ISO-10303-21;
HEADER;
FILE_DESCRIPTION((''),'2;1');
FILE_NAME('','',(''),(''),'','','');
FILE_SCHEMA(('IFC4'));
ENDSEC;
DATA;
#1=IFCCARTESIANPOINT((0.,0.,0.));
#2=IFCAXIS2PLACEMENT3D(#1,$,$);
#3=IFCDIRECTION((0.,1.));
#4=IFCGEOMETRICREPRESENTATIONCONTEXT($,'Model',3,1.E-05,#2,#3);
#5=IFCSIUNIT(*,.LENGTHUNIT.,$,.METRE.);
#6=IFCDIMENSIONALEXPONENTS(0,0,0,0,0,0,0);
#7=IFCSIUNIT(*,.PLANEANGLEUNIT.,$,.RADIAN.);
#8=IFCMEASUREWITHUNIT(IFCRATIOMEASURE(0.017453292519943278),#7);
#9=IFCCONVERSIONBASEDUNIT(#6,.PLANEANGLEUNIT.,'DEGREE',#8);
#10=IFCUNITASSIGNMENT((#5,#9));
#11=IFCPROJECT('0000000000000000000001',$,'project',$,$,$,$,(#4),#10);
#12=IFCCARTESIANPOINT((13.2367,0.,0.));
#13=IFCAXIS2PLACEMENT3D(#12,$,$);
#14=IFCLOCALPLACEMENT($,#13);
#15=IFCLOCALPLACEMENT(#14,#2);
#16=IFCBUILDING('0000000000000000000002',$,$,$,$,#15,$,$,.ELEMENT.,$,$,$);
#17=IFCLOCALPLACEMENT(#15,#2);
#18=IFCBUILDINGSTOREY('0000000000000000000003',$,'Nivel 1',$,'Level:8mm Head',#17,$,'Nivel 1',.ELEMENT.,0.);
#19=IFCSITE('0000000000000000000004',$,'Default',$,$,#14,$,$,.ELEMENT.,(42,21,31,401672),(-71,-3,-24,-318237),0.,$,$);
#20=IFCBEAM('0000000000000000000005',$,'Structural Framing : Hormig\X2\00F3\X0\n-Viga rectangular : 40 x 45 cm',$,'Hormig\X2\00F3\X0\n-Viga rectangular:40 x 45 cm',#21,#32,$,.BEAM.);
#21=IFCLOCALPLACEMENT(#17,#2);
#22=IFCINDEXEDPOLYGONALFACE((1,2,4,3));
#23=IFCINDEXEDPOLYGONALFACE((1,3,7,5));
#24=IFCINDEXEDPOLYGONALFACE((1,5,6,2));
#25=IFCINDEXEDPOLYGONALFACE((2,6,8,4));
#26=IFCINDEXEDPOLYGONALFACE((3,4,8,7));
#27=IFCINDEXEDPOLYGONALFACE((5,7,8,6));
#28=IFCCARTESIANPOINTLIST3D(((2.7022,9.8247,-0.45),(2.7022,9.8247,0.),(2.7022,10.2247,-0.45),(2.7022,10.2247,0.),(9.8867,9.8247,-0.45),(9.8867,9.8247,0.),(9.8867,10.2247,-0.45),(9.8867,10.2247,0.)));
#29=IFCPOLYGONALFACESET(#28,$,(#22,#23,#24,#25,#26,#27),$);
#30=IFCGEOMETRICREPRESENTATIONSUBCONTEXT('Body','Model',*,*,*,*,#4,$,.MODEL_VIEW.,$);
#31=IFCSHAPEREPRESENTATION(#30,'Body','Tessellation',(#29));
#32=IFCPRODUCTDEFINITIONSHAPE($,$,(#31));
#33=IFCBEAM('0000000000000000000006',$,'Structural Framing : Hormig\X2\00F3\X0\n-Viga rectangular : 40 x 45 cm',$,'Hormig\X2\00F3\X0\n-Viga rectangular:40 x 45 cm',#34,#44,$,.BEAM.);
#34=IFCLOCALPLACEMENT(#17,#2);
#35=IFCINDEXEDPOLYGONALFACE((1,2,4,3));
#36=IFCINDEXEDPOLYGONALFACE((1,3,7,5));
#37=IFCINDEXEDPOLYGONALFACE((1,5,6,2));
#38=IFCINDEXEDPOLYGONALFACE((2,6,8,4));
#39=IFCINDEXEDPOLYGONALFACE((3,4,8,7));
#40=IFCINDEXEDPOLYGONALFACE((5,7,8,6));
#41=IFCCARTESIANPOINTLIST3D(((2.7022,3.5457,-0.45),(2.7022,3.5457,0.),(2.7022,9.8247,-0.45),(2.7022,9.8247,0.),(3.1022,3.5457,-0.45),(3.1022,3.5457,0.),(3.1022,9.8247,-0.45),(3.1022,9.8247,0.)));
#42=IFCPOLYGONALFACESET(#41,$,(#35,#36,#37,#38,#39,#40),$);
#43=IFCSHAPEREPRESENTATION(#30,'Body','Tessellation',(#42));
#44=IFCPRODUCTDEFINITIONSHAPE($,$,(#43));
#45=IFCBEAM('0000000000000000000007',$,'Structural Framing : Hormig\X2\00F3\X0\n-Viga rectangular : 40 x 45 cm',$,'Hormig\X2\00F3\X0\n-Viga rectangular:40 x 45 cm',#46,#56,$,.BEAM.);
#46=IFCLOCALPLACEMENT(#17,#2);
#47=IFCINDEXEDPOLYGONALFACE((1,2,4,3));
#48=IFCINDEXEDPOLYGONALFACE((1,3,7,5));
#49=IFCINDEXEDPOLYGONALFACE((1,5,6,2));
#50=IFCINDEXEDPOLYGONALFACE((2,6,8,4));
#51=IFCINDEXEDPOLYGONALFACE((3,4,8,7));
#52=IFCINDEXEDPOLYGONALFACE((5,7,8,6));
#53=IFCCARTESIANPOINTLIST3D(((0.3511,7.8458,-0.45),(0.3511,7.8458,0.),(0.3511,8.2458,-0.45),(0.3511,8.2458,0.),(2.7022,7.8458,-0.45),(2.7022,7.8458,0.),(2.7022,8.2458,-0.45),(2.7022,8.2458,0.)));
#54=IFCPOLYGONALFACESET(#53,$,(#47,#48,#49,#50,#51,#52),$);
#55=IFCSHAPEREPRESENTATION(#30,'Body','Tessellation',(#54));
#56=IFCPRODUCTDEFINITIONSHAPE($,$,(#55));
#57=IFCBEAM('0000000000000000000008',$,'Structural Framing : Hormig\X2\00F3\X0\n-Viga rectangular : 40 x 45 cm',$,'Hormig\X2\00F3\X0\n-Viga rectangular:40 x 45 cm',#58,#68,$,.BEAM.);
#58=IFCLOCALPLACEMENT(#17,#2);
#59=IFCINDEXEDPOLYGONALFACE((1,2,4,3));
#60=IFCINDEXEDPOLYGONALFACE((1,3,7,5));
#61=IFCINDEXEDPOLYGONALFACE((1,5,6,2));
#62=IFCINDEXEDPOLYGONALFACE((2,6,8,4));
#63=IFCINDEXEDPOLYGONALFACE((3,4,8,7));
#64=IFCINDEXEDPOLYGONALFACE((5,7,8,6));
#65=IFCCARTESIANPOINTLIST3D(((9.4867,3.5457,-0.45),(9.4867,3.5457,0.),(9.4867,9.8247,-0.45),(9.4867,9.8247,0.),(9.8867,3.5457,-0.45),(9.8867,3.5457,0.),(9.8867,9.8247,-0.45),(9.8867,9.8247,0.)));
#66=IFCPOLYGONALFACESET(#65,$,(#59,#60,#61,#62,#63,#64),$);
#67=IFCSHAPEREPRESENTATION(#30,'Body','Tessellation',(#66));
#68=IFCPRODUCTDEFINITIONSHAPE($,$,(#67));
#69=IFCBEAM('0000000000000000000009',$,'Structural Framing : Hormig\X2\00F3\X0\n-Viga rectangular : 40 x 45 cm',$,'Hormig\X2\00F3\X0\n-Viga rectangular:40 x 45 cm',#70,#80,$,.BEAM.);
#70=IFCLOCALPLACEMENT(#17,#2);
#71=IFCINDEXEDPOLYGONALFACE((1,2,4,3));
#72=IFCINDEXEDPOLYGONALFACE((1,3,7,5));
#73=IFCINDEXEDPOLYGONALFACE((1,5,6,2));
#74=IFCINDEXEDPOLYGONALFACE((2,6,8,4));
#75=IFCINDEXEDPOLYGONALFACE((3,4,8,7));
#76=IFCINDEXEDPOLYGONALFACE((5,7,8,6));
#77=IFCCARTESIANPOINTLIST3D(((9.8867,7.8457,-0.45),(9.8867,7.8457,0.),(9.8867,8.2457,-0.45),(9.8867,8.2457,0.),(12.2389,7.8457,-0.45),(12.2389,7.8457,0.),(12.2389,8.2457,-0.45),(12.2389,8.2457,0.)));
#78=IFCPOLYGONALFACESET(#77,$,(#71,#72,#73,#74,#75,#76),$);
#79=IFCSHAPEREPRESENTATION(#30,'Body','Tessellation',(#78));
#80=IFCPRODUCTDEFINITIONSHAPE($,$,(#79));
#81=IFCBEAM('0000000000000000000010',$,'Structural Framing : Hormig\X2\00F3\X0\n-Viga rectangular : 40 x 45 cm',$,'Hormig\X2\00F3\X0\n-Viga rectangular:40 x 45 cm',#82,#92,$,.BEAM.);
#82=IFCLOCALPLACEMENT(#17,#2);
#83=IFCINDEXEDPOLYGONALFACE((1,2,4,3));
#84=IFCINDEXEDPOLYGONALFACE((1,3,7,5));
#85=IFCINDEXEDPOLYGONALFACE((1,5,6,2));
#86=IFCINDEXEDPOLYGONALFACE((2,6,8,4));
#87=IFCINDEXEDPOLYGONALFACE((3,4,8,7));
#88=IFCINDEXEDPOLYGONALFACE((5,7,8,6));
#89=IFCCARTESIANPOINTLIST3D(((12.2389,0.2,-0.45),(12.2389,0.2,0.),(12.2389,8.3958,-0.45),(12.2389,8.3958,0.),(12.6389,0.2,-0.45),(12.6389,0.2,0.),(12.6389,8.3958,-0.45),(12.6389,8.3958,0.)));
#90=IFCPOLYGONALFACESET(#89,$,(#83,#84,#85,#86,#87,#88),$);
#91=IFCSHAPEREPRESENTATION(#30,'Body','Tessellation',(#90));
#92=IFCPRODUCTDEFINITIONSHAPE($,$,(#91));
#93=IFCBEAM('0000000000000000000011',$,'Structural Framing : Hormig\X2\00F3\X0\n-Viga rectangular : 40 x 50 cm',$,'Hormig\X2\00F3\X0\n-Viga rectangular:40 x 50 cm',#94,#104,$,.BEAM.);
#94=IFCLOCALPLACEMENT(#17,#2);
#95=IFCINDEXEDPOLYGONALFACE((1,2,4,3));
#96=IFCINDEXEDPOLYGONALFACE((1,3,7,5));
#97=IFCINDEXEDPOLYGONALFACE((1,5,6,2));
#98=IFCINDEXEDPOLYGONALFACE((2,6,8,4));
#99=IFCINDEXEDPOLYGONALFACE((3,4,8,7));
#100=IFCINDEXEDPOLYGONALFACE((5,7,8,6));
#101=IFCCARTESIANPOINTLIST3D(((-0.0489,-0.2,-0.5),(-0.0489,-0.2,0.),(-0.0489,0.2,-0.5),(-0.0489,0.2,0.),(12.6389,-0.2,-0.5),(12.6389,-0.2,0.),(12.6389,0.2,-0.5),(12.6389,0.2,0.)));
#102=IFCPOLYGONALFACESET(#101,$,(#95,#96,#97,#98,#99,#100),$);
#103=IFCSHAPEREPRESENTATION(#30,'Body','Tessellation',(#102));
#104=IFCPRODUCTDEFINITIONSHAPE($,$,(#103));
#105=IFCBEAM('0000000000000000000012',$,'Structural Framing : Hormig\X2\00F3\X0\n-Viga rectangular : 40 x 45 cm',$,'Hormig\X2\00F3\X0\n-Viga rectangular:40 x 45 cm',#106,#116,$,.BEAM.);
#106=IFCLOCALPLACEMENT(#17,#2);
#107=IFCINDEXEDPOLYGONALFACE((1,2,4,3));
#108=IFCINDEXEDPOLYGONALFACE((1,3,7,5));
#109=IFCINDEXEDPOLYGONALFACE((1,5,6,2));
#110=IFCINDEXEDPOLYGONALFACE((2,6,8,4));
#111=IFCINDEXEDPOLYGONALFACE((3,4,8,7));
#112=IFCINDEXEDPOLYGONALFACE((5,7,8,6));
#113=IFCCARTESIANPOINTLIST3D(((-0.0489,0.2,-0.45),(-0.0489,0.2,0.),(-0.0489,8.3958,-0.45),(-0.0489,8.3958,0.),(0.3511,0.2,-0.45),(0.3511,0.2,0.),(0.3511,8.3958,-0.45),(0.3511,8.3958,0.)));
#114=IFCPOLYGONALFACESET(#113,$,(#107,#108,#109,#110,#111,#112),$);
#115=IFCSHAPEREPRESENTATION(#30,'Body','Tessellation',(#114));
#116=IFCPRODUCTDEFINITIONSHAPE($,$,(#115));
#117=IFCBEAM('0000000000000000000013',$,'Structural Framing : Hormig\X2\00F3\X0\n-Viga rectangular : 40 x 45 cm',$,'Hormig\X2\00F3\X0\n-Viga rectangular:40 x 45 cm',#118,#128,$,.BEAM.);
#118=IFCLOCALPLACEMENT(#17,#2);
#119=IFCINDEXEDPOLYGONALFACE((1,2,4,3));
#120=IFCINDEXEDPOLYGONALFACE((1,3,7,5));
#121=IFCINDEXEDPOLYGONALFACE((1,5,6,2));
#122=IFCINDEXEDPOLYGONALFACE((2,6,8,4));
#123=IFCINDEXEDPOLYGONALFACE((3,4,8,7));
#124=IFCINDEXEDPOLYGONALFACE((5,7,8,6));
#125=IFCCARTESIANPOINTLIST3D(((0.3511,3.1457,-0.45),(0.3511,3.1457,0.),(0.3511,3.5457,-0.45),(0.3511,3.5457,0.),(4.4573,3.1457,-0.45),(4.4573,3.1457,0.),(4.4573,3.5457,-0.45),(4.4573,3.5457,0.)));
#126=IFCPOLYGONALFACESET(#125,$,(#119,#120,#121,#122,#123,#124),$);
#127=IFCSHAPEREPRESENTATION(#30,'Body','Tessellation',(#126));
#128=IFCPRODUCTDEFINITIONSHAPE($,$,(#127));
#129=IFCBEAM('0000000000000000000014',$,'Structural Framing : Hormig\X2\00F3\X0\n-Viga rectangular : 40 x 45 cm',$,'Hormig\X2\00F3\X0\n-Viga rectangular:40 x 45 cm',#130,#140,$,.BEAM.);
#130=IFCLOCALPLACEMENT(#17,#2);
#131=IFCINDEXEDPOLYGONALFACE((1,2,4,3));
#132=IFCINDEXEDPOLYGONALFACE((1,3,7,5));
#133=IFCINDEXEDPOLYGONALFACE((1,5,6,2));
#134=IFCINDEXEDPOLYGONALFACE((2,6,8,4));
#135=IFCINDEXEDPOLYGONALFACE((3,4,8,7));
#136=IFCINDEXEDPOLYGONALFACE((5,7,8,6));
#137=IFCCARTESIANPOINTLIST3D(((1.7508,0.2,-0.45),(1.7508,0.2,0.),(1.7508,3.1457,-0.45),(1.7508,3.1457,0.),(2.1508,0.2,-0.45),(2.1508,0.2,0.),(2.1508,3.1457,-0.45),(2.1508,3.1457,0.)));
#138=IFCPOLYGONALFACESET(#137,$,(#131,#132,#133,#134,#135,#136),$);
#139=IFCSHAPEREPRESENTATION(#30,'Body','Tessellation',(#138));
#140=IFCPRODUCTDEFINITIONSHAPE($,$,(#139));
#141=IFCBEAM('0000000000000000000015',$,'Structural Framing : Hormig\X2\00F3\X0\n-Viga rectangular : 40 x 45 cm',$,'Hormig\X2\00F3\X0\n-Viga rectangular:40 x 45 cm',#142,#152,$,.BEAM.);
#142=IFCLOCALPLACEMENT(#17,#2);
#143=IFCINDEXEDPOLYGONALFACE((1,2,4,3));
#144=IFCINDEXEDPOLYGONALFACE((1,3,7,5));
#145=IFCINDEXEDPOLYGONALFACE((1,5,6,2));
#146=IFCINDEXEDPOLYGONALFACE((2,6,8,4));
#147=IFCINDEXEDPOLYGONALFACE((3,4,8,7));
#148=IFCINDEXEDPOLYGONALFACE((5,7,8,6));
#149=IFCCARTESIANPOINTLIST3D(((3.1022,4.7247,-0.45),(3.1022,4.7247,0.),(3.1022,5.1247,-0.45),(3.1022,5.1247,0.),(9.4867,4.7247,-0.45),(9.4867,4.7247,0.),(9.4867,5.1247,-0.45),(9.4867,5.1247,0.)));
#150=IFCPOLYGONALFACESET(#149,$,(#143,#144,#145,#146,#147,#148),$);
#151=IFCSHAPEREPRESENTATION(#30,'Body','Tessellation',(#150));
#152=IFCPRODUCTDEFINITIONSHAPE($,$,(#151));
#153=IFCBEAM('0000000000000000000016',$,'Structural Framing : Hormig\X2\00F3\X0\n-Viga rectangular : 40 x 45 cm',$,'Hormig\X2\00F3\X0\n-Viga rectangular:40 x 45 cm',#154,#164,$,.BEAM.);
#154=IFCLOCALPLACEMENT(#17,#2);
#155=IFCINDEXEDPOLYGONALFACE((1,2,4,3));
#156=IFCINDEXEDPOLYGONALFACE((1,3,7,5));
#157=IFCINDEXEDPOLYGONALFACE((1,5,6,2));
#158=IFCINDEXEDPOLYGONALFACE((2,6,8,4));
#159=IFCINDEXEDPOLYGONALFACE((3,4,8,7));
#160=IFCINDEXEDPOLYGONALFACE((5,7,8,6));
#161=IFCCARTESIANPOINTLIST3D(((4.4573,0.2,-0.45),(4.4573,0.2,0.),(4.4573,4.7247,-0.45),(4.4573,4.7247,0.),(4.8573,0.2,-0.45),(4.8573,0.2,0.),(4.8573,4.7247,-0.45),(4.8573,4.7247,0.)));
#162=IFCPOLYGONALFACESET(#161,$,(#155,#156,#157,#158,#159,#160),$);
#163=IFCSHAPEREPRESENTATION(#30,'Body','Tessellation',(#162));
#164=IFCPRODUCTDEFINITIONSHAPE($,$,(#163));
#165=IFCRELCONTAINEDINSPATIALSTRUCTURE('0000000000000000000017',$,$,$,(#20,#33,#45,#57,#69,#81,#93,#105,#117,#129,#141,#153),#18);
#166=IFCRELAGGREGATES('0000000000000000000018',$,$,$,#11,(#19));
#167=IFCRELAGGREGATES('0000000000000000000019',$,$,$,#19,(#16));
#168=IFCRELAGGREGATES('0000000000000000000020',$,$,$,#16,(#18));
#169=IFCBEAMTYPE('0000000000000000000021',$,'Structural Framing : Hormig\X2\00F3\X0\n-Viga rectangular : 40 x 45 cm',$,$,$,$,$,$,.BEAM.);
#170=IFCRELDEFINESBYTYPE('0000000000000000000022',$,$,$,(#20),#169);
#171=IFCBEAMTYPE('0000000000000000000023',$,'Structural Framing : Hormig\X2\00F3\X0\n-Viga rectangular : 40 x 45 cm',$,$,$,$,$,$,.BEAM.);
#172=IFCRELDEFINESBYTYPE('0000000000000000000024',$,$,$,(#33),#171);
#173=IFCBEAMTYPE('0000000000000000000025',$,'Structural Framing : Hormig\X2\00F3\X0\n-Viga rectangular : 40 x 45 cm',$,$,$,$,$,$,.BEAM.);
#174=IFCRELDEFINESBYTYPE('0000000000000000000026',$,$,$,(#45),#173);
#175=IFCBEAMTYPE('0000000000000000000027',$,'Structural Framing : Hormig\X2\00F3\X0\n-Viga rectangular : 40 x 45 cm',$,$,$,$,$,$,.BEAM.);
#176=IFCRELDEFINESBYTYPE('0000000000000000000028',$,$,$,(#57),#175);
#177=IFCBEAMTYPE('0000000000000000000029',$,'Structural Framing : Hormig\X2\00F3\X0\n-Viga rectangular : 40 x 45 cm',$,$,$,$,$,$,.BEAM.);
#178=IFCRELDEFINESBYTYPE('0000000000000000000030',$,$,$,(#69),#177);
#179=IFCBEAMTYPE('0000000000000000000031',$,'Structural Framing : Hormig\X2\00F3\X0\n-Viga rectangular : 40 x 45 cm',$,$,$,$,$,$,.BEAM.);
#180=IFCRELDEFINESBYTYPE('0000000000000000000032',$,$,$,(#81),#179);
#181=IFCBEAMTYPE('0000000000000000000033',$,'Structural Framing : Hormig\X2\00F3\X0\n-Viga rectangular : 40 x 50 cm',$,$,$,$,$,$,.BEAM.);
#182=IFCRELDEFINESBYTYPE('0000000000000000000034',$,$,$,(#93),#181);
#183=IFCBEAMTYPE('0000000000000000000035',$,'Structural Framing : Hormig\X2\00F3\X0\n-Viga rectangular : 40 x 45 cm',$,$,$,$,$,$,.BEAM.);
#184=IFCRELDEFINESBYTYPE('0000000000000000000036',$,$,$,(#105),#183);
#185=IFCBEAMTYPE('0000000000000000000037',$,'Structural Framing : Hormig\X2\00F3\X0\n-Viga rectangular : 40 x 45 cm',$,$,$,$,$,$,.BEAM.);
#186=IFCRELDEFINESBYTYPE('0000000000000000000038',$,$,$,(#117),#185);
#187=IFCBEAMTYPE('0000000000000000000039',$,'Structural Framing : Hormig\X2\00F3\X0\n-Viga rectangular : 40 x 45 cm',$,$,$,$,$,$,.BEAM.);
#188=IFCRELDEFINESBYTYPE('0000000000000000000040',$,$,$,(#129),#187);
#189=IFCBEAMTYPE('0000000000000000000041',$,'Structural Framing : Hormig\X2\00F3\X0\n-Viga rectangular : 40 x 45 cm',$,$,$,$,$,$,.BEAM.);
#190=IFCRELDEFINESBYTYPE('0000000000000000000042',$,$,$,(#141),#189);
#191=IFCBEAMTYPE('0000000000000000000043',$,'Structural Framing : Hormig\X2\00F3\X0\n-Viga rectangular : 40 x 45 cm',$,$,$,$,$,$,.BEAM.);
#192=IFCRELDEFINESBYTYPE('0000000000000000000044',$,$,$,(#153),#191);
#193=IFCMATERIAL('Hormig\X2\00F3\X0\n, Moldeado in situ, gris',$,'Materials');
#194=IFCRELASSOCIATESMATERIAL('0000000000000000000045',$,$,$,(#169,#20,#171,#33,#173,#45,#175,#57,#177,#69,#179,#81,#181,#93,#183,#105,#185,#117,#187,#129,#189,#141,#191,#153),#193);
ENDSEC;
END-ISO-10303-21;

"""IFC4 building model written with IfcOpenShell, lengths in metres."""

from ifc_helpers import new_model, entity, si_unit, converted_unit, direction, frame, origin, place, context, subcontext, project, spatial, indexed_curve, outline, extrude, source, transform, mapped, material, type_object, type_shapes, element, save


model = new_model("IFC4")

# Units and contexts
model_context = context("Model", 3, precision=1e-05, world=origin(), true_north=direction((0.0, 1.0)))
body_context = subcontext(model_context, "Body", "Model", "MODEL_VIEW")
ifc_project = project(units=[si_unit("LENGTHUNIT", "METRE"), converted_unit("PLANEANGLEUNIT", "DEGREE", entity("IfcRatioMeasure", 0.017453292519943278), si_unit("PLANEANGLEUNIT", "RADIAN"), dimensions=[0, 0, 0, 0, 0, 0, 0])], contexts=[model_context])

# Site, building, storey
site_placement = place(None, frame((13.2367, 0.0, 0.0)))
site = spatial("IfcSite", under=ifc_project, at=site_placement, Name="Default", CompositionType="ELEMENT", RefLatitude=(42, 21, 31, 401672), RefLongitude=(-71, -3, -24, -318237), RefElevation=0.0)
building_placement = place(site_placement, origin())
building = spatial("IfcBuilding", under=site, at=building_placement, CompositionType="ELEMENT")
storey_placement = place(building_placement, origin())
storey = spatial("IfcBuildingStorey", under=building, at=storey_placement, Name="Nivel 1", ObjectType="Level:8mm Head", LongName="Nivel 1", CompositionType="ELEMENT", Elevation=0.0)

# Beams
ifc_material_1 = material(Name="Hormigón, Moldeado in situ, gris", Category="Materials")
beam_type_1 = type_object("IfcBeamType", Name="Structural Framing : Hormigón-Viga rectangular : 40 x 45 cm", PredefinedType="BEAM", material=ifc_material_1)
shared_shape_1 = source(origin(), body_context, "Body", "SweptSolid", [
    extrude(outline(indexed_curve([(-0.225, -0.2), (0.225, -0.2), (0.225, 0.2), (-0.225, 0.2), (-0.225, -0.2)], self_intersect=False)), frame((2.7022, 10.0247, -0.225), z_axis=(1.0, 0.0, 0.0), x_axis=(0.0, 0.0, -1.0)), (0.0, 0.0, 1.0), 7.1845),
])
type_shapes(beam_type_1, [shared_shape_1])
beam_1_placement = place(storey_placement, origin())
element("IfcBeam", 1, at=beam_1_placement, inside=storey, type_object=beam_type_1, material=ifc_material_1, Name="Structural Framing : Hormigón-Viga rectangular : 40 x 45 cm", ObjectType="Hormigón-Viga rectangular:40 x 45 cm", PredefinedType="BEAM", context=body_context, shape_type="MappedRepresentation", body=[
    mapped(shared_shape_1, transform((0.0, 0.0, 0.0), scale=1.0)),
])
beam_type_2 = type_object("IfcBeamType", Name="Structural Framing : Hormigón-Viga rectangular : 40 x 45 cm", PredefinedType="BEAM", material=ifc_material_1)
shared_shape_2 = source(origin(), body_context, "Body", "SweptSolid", [
    extrude(outline(indexed_curve([(-0.2, -0.225), (0.2, -0.225), (0.2, 0.225), (-0.2, 0.225), (-0.2, -0.225)], self_intersect=False)), frame((2.9022, 3.5457, -0.225), z_axis=(0.0, 1.0, 0.0), x_axis=(-1.0, 0.0, 0.0)), (0.0, 0.0, 1.0), 6.279),
])
type_shapes(beam_type_2, [shared_shape_2])
beam_2_placement = place(storey_placement, origin())
element("IfcBeam", 2, at=beam_2_placement, inside=storey, type_object=beam_type_2, material=ifc_material_1, Name="Structural Framing : Hormigón-Viga rectangular : 40 x 45 cm", ObjectType="Hormigón-Viga rectangular:40 x 45 cm", PredefinedType="BEAM", context=body_context, shape_type="MappedRepresentation", body=[
    mapped(shared_shape_2, transform((0.0, 0.0, 0.0), scale=1.0)),
])
beam_type_3 = type_object("IfcBeamType", Name="Structural Framing : Hormigón-Viga rectangular : 40 x 45 cm", PredefinedType="BEAM", material=ifc_material_1)
shared_shape_3 = source(origin(), body_context, "Body", "SweptSolid", [
    extrude(outline(indexed_curve([(-0.225, -0.2), (0.225, -0.2), (0.225, 0.2), (-0.225, 0.2), (-0.225, -0.2)], self_intersect=False)), frame((0.3511, 8.0458, -0.225), z_axis=(1.0, 0.0, 0.0), x_axis=(0.0, 0.0, -1.0)), (0.0, 0.0, 1.0), 2.351),
])
type_shapes(beam_type_3, [shared_shape_3])
beam_3_placement = place(storey_placement, origin())
element("IfcBeam", 3, at=beam_3_placement, inside=storey, type_object=beam_type_3, material=ifc_material_1, Name="Structural Framing : Hormigón-Viga rectangular : 40 x 45 cm", ObjectType="Hormigón-Viga rectangular:40 x 45 cm", PredefinedType="BEAM", context=body_context, shape_type="MappedRepresentation", body=[
    mapped(shared_shape_3, transform((0.0, 0.0, 0.0), scale=1.0)),
])
beam_type_4 = type_object("IfcBeamType", Name="Structural Framing : Hormigón-Viga rectangular : 40 x 45 cm", PredefinedType="BEAM", material=ifc_material_1)
shared_shape_4 = source(origin(), body_context, "Body", "SweptSolid", [
    extrude(outline(indexed_curve([(-0.2, -0.225), (0.2, -0.225), (0.2, 0.225), (-0.2, 0.225), (-0.2, -0.225)], self_intersect=False)), frame((9.6867, 9.8247, -0.225), z_axis=(0.0, -1.0, 0.0), x_axis=(-1.0, 0.0, 0.0)), (0.0, 0.0, 1.0), 6.279),
])
type_shapes(beam_type_4, [shared_shape_4])
beam_4_placement = place(storey_placement, origin())
element("IfcBeam", 4, at=beam_4_placement, inside=storey, type_object=beam_type_4, material=ifc_material_1, Name="Structural Framing : Hormigón-Viga rectangular : 40 x 45 cm", ObjectType="Hormigón-Viga rectangular:40 x 45 cm", PredefinedType="BEAM", context=body_context, shape_type="MappedRepresentation", body=[
    mapped(shared_shape_4, transform((0.0, 0.0, 0.0), scale=1.0)),
])
beam_type_5 = type_object("IfcBeamType", Name="Structural Framing : Hormigón-Viga rectangular : 40 x 45 cm", PredefinedType="BEAM", material=ifc_material_1)
shared_shape_5 = source(origin(), body_context, "Body", "SweptSolid", [
    extrude(outline(indexed_curve([(-0.225, -0.2), (0.225, -0.2), (0.225, 0.2), (-0.225, 0.2), (-0.225, -0.2)], self_intersect=False)), frame((9.8867, 8.0457, -0.225), z_axis=(1.0, 0.0, 0.0), x_axis=(0.0, 0.0, -1.0)), (0.0, 0.0, 1.0), 2.3522),
])
type_shapes(beam_type_5, [shared_shape_5])
beam_5_placement = place(storey_placement, origin())
element("IfcBeam", 5, at=beam_5_placement, inside=storey, type_object=beam_type_5, material=ifc_material_1, Name="Structural Framing : Hormigón-Viga rectangular : 40 x 45 cm", ObjectType="Hormigón-Viga rectangular:40 x 45 cm", PredefinedType="BEAM", context=body_context, shape_type="MappedRepresentation", body=[
    mapped(shared_shape_5, transform((0.0, 0.0, 0.0), scale=1.0)),
])
beam_type_6 = type_object("IfcBeamType", Name="Structural Framing : Hormigón-Viga rectangular : 40 x 45 cm", PredefinedType="BEAM", material=ifc_material_1)
shared_shape_6 = source(origin(), body_context, "Body", "SweptSolid", [
    extrude(outline(indexed_curve([(-0.2, -0.225), (0.2, -0.225), (0.2, 0.225), (-0.2, 0.225), (-0.2, -0.225)], self_intersect=False)), frame((12.4389, 8.3958, -0.225), z_axis=(0.0, -1.0, 0.0), x_axis=(-1.0, 0.0, 0.0)), (0.0, 0.0, 1.0), 8.1958),
])
type_shapes(beam_type_6, [shared_shape_6])
beam_6_placement = place(storey_placement, origin())
element("IfcBeam", 6, at=beam_6_placement, inside=storey, type_object=beam_type_6, material=ifc_material_1, Name="Structural Framing : Hormigón-Viga rectangular : 40 x 45 cm", ObjectType="Hormigón-Viga rectangular:40 x 45 cm", PredefinedType="BEAM", context=body_context, shape_type="MappedRepresentation", body=[
    mapped(shared_shape_6, transform((0.0, 0.0, 0.0), scale=1.0)),
])
beam_type_7 = type_object("IfcBeamType", Name="Structural Framing : Hormigón-Viga rectangular : 40 x 50 cm", PredefinedType="BEAM", material=ifc_material_1)
shared_shape_7 = source(origin(), body_context, "Body", "SweptSolid", [
    extrude(outline(indexed_curve([(-0.25, -0.2), (0.25, -0.2), (0.25, 0.2), (-0.25, 0.2), (-0.25, -0.2)], self_intersect=False)), frame((12.6389, 0.0, -0.25), z_axis=(-1.0, 0.0, 0.0), x_axis=(0.0, 0.0, -1.0)), (0.0, 0.0, 1.0), 12.6878),
])
type_shapes(beam_type_7, [shared_shape_7])
beam_7_placement = place(storey_placement, origin())
element("IfcBeam", 7, at=beam_7_placement, inside=storey, type_object=beam_type_7, material=ifc_material_1, Name="Structural Framing : Hormigón-Viga rectangular : 40 x 50 cm", ObjectType="Hormigón-Viga rectangular:40 x 50 cm", PredefinedType="BEAM", context=body_context, shape_type="MappedRepresentation", body=[
    mapped(shared_shape_7, transform((0.0, 0.0, 0.0), scale=1.0)),
])
beam_type_8 = type_object("IfcBeamType", Name="Structural Framing : Hormigón-Viga rectangular : 40 x 45 cm", PredefinedType="BEAM", material=ifc_material_1)
shared_shape_8 = source(origin(), body_context, "Body", "SweptSolid", [
    extrude(outline(indexed_curve([(-0.2, -0.225), (0.2, -0.225), (0.2, 0.225), (-0.2, 0.225), (-0.2, -0.225)], self_intersect=False)), frame((0.1511, 0.2, -0.225), z_axis=(0.0, 1.0, 0.0), x_axis=(-1.0, 0.0, 0.0)), (0.0, 0.0, 1.0), 8.1958),
])
type_shapes(beam_type_8, [shared_shape_8])
beam_8_placement = place(storey_placement, origin())
element("IfcBeam", 8, at=beam_8_placement, inside=storey, type_object=beam_type_8, material=ifc_material_1, Name="Structural Framing : Hormigón-Viga rectangular : 40 x 45 cm", ObjectType="Hormigón-Viga rectangular:40 x 45 cm", PredefinedType="BEAM", context=body_context, shape_type="MappedRepresentation", body=[
    mapped(shared_shape_8, transform((0.0, 0.0, 0.0), scale=1.0)),
])
beam_type_9 = type_object("IfcBeamType", Name="Structural Framing : Hormigón-Viga rectangular : 40 x 45 cm", PredefinedType="BEAM", material=ifc_material_1)
shared_shape_9 = source(origin(), body_context, "Body", "SweptSolid", [
    extrude(outline(indexed_curve([(-0.225, -0.2), (0.225, -0.2), (0.225, 0.2), (-0.225, 0.2), (-0.225, -0.2)], self_intersect=False)), frame((0.3511, 3.3457, -0.225), z_axis=(1.0, 0.0, 0.0), x_axis=(0.0, 0.0, -1.0)), (0.0, 0.0, 1.0), 4.1062),
])
type_shapes(beam_type_9, [shared_shape_9])
beam_9_placement = place(storey_placement, origin())
element("IfcBeam", 9, at=beam_9_placement, inside=storey, type_object=beam_type_9, material=ifc_material_1, Name="Structural Framing : Hormigón-Viga rectangular : 40 x 45 cm", ObjectType="Hormigón-Viga rectangular:40 x 45 cm", PredefinedType="BEAM", context=body_context, shape_type="MappedRepresentation", body=[
    mapped(shared_shape_9, transform((0.0, 0.0, 0.0), scale=1.0)),
])
beam_type_10 = type_object("IfcBeamType", Name="Structural Framing : Hormigón-Viga rectangular : 40 x 45 cm", PredefinedType="BEAM", material=ifc_material_1)
shared_shape_10 = source(origin(), body_context, "Body", "SweptSolid", [
    extrude(outline(indexed_curve([(-0.2, -0.225), (0.2, -0.225), (0.2, 0.225), (-0.2, 0.225), (-0.2, -0.225)], self_intersect=False)), frame((1.9508, 3.1457, -0.225), z_axis=(0.0, -1.0, 0.0), x_axis=(-1.0, 0.0, 0.0)), (0.0, 0.0, 1.0), 2.9457),
])
type_shapes(beam_type_10, [shared_shape_10])
beam_10_placement = place(storey_placement, origin())
element("IfcBeam", 10, at=beam_10_placement, inside=storey, type_object=beam_type_10, material=ifc_material_1, Name="Structural Framing : Hormigón-Viga rectangular : 40 x 45 cm", ObjectType="Hormigón-Viga rectangular:40 x 45 cm", PredefinedType="BEAM", context=body_context, shape_type="MappedRepresentation", body=[
    mapped(shared_shape_10, transform((0.0, 0.0, 0.0), scale=1.0)),
])
beam_type_11 = type_object("IfcBeamType", Name="Structural Framing : Hormigón-Viga rectangular : 40 x 45 cm", PredefinedType="BEAM", material=ifc_material_1)
shared_shape_11 = source(origin(), body_context, "Body", "SweptSolid", [
    extrude(outline(indexed_curve([(-0.225, -0.2), (0.225, -0.2), (0.225, 0.2), (-0.225, 0.2), (-0.225, -0.2)], self_intersect=False)), frame((3.1022, 4.9247, -0.225), z_axis=(1.0, 0.0, 0.0), x_axis=(0.0, 0.0, -1.0)), (0.0, 0.0, 1.0), 6.3845),
])
type_shapes(beam_type_11, [shared_shape_11])
beam_11_placement = place(storey_placement, origin())
element("IfcBeam", 11, at=beam_11_placement, inside=storey, type_object=beam_type_11, material=ifc_material_1, Name="Structural Framing : Hormigón-Viga rectangular : 40 x 45 cm", ObjectType="Hormigón-Viga rectangular:40 x 45 cm", PredefinedType="BEAM", context=body_context, shape_type="MappedRepresentation", body=[
    mapped(shared_shape_11, transform((0.0, 0.0, 0.0), scale=1.0)),
])
beam_type_12 = type_object("IfcBeamType", Name="Structural Framing : Hormigón-Viga rectangular : 40 x 45 cm", PredefinedType="BEAM", material=ifc_material_1)
shared_shape_12 = source(origin(), body_context, "Body", "SweptSolid", [
    extrude(outline(indexed_curve([(-0.2, -0.225), (0.2, -0.225), (0.2, 0.225), (-0.2, 0.225), (-0.2, -0.225)], self_intersect=False)), frame((4.6573, 4.7247, -0.225), z_axis=(0.0, -1.0, 0.0), x_axis=(-1.0, 0.0, 0.0)), (0.0, 0.0, 1.0), 4.5247),
])
type_shapes(beam_type_12, [shared_shape_12])
beam_12_placement = place(storey_placement, origin())
element("IfcBeam", 12, at=beam_12_placement, inside=storey, type_object=beam_type_12, material=ifc_material_1, Name="Structural Framing : Hormigón-Viga rectangular : 40 x 45 cm", ObjectType="Hormigón-Viga rectangular:40 x 45 cm", PredefinedType="BEAM", context=body_context, shape_type="MappedRepresentation", body=[
    mapped(shared_shape_12, transform((0.0, 0.0, 0.0), scale=1.0)),
])

save(model, "model.ifc")
